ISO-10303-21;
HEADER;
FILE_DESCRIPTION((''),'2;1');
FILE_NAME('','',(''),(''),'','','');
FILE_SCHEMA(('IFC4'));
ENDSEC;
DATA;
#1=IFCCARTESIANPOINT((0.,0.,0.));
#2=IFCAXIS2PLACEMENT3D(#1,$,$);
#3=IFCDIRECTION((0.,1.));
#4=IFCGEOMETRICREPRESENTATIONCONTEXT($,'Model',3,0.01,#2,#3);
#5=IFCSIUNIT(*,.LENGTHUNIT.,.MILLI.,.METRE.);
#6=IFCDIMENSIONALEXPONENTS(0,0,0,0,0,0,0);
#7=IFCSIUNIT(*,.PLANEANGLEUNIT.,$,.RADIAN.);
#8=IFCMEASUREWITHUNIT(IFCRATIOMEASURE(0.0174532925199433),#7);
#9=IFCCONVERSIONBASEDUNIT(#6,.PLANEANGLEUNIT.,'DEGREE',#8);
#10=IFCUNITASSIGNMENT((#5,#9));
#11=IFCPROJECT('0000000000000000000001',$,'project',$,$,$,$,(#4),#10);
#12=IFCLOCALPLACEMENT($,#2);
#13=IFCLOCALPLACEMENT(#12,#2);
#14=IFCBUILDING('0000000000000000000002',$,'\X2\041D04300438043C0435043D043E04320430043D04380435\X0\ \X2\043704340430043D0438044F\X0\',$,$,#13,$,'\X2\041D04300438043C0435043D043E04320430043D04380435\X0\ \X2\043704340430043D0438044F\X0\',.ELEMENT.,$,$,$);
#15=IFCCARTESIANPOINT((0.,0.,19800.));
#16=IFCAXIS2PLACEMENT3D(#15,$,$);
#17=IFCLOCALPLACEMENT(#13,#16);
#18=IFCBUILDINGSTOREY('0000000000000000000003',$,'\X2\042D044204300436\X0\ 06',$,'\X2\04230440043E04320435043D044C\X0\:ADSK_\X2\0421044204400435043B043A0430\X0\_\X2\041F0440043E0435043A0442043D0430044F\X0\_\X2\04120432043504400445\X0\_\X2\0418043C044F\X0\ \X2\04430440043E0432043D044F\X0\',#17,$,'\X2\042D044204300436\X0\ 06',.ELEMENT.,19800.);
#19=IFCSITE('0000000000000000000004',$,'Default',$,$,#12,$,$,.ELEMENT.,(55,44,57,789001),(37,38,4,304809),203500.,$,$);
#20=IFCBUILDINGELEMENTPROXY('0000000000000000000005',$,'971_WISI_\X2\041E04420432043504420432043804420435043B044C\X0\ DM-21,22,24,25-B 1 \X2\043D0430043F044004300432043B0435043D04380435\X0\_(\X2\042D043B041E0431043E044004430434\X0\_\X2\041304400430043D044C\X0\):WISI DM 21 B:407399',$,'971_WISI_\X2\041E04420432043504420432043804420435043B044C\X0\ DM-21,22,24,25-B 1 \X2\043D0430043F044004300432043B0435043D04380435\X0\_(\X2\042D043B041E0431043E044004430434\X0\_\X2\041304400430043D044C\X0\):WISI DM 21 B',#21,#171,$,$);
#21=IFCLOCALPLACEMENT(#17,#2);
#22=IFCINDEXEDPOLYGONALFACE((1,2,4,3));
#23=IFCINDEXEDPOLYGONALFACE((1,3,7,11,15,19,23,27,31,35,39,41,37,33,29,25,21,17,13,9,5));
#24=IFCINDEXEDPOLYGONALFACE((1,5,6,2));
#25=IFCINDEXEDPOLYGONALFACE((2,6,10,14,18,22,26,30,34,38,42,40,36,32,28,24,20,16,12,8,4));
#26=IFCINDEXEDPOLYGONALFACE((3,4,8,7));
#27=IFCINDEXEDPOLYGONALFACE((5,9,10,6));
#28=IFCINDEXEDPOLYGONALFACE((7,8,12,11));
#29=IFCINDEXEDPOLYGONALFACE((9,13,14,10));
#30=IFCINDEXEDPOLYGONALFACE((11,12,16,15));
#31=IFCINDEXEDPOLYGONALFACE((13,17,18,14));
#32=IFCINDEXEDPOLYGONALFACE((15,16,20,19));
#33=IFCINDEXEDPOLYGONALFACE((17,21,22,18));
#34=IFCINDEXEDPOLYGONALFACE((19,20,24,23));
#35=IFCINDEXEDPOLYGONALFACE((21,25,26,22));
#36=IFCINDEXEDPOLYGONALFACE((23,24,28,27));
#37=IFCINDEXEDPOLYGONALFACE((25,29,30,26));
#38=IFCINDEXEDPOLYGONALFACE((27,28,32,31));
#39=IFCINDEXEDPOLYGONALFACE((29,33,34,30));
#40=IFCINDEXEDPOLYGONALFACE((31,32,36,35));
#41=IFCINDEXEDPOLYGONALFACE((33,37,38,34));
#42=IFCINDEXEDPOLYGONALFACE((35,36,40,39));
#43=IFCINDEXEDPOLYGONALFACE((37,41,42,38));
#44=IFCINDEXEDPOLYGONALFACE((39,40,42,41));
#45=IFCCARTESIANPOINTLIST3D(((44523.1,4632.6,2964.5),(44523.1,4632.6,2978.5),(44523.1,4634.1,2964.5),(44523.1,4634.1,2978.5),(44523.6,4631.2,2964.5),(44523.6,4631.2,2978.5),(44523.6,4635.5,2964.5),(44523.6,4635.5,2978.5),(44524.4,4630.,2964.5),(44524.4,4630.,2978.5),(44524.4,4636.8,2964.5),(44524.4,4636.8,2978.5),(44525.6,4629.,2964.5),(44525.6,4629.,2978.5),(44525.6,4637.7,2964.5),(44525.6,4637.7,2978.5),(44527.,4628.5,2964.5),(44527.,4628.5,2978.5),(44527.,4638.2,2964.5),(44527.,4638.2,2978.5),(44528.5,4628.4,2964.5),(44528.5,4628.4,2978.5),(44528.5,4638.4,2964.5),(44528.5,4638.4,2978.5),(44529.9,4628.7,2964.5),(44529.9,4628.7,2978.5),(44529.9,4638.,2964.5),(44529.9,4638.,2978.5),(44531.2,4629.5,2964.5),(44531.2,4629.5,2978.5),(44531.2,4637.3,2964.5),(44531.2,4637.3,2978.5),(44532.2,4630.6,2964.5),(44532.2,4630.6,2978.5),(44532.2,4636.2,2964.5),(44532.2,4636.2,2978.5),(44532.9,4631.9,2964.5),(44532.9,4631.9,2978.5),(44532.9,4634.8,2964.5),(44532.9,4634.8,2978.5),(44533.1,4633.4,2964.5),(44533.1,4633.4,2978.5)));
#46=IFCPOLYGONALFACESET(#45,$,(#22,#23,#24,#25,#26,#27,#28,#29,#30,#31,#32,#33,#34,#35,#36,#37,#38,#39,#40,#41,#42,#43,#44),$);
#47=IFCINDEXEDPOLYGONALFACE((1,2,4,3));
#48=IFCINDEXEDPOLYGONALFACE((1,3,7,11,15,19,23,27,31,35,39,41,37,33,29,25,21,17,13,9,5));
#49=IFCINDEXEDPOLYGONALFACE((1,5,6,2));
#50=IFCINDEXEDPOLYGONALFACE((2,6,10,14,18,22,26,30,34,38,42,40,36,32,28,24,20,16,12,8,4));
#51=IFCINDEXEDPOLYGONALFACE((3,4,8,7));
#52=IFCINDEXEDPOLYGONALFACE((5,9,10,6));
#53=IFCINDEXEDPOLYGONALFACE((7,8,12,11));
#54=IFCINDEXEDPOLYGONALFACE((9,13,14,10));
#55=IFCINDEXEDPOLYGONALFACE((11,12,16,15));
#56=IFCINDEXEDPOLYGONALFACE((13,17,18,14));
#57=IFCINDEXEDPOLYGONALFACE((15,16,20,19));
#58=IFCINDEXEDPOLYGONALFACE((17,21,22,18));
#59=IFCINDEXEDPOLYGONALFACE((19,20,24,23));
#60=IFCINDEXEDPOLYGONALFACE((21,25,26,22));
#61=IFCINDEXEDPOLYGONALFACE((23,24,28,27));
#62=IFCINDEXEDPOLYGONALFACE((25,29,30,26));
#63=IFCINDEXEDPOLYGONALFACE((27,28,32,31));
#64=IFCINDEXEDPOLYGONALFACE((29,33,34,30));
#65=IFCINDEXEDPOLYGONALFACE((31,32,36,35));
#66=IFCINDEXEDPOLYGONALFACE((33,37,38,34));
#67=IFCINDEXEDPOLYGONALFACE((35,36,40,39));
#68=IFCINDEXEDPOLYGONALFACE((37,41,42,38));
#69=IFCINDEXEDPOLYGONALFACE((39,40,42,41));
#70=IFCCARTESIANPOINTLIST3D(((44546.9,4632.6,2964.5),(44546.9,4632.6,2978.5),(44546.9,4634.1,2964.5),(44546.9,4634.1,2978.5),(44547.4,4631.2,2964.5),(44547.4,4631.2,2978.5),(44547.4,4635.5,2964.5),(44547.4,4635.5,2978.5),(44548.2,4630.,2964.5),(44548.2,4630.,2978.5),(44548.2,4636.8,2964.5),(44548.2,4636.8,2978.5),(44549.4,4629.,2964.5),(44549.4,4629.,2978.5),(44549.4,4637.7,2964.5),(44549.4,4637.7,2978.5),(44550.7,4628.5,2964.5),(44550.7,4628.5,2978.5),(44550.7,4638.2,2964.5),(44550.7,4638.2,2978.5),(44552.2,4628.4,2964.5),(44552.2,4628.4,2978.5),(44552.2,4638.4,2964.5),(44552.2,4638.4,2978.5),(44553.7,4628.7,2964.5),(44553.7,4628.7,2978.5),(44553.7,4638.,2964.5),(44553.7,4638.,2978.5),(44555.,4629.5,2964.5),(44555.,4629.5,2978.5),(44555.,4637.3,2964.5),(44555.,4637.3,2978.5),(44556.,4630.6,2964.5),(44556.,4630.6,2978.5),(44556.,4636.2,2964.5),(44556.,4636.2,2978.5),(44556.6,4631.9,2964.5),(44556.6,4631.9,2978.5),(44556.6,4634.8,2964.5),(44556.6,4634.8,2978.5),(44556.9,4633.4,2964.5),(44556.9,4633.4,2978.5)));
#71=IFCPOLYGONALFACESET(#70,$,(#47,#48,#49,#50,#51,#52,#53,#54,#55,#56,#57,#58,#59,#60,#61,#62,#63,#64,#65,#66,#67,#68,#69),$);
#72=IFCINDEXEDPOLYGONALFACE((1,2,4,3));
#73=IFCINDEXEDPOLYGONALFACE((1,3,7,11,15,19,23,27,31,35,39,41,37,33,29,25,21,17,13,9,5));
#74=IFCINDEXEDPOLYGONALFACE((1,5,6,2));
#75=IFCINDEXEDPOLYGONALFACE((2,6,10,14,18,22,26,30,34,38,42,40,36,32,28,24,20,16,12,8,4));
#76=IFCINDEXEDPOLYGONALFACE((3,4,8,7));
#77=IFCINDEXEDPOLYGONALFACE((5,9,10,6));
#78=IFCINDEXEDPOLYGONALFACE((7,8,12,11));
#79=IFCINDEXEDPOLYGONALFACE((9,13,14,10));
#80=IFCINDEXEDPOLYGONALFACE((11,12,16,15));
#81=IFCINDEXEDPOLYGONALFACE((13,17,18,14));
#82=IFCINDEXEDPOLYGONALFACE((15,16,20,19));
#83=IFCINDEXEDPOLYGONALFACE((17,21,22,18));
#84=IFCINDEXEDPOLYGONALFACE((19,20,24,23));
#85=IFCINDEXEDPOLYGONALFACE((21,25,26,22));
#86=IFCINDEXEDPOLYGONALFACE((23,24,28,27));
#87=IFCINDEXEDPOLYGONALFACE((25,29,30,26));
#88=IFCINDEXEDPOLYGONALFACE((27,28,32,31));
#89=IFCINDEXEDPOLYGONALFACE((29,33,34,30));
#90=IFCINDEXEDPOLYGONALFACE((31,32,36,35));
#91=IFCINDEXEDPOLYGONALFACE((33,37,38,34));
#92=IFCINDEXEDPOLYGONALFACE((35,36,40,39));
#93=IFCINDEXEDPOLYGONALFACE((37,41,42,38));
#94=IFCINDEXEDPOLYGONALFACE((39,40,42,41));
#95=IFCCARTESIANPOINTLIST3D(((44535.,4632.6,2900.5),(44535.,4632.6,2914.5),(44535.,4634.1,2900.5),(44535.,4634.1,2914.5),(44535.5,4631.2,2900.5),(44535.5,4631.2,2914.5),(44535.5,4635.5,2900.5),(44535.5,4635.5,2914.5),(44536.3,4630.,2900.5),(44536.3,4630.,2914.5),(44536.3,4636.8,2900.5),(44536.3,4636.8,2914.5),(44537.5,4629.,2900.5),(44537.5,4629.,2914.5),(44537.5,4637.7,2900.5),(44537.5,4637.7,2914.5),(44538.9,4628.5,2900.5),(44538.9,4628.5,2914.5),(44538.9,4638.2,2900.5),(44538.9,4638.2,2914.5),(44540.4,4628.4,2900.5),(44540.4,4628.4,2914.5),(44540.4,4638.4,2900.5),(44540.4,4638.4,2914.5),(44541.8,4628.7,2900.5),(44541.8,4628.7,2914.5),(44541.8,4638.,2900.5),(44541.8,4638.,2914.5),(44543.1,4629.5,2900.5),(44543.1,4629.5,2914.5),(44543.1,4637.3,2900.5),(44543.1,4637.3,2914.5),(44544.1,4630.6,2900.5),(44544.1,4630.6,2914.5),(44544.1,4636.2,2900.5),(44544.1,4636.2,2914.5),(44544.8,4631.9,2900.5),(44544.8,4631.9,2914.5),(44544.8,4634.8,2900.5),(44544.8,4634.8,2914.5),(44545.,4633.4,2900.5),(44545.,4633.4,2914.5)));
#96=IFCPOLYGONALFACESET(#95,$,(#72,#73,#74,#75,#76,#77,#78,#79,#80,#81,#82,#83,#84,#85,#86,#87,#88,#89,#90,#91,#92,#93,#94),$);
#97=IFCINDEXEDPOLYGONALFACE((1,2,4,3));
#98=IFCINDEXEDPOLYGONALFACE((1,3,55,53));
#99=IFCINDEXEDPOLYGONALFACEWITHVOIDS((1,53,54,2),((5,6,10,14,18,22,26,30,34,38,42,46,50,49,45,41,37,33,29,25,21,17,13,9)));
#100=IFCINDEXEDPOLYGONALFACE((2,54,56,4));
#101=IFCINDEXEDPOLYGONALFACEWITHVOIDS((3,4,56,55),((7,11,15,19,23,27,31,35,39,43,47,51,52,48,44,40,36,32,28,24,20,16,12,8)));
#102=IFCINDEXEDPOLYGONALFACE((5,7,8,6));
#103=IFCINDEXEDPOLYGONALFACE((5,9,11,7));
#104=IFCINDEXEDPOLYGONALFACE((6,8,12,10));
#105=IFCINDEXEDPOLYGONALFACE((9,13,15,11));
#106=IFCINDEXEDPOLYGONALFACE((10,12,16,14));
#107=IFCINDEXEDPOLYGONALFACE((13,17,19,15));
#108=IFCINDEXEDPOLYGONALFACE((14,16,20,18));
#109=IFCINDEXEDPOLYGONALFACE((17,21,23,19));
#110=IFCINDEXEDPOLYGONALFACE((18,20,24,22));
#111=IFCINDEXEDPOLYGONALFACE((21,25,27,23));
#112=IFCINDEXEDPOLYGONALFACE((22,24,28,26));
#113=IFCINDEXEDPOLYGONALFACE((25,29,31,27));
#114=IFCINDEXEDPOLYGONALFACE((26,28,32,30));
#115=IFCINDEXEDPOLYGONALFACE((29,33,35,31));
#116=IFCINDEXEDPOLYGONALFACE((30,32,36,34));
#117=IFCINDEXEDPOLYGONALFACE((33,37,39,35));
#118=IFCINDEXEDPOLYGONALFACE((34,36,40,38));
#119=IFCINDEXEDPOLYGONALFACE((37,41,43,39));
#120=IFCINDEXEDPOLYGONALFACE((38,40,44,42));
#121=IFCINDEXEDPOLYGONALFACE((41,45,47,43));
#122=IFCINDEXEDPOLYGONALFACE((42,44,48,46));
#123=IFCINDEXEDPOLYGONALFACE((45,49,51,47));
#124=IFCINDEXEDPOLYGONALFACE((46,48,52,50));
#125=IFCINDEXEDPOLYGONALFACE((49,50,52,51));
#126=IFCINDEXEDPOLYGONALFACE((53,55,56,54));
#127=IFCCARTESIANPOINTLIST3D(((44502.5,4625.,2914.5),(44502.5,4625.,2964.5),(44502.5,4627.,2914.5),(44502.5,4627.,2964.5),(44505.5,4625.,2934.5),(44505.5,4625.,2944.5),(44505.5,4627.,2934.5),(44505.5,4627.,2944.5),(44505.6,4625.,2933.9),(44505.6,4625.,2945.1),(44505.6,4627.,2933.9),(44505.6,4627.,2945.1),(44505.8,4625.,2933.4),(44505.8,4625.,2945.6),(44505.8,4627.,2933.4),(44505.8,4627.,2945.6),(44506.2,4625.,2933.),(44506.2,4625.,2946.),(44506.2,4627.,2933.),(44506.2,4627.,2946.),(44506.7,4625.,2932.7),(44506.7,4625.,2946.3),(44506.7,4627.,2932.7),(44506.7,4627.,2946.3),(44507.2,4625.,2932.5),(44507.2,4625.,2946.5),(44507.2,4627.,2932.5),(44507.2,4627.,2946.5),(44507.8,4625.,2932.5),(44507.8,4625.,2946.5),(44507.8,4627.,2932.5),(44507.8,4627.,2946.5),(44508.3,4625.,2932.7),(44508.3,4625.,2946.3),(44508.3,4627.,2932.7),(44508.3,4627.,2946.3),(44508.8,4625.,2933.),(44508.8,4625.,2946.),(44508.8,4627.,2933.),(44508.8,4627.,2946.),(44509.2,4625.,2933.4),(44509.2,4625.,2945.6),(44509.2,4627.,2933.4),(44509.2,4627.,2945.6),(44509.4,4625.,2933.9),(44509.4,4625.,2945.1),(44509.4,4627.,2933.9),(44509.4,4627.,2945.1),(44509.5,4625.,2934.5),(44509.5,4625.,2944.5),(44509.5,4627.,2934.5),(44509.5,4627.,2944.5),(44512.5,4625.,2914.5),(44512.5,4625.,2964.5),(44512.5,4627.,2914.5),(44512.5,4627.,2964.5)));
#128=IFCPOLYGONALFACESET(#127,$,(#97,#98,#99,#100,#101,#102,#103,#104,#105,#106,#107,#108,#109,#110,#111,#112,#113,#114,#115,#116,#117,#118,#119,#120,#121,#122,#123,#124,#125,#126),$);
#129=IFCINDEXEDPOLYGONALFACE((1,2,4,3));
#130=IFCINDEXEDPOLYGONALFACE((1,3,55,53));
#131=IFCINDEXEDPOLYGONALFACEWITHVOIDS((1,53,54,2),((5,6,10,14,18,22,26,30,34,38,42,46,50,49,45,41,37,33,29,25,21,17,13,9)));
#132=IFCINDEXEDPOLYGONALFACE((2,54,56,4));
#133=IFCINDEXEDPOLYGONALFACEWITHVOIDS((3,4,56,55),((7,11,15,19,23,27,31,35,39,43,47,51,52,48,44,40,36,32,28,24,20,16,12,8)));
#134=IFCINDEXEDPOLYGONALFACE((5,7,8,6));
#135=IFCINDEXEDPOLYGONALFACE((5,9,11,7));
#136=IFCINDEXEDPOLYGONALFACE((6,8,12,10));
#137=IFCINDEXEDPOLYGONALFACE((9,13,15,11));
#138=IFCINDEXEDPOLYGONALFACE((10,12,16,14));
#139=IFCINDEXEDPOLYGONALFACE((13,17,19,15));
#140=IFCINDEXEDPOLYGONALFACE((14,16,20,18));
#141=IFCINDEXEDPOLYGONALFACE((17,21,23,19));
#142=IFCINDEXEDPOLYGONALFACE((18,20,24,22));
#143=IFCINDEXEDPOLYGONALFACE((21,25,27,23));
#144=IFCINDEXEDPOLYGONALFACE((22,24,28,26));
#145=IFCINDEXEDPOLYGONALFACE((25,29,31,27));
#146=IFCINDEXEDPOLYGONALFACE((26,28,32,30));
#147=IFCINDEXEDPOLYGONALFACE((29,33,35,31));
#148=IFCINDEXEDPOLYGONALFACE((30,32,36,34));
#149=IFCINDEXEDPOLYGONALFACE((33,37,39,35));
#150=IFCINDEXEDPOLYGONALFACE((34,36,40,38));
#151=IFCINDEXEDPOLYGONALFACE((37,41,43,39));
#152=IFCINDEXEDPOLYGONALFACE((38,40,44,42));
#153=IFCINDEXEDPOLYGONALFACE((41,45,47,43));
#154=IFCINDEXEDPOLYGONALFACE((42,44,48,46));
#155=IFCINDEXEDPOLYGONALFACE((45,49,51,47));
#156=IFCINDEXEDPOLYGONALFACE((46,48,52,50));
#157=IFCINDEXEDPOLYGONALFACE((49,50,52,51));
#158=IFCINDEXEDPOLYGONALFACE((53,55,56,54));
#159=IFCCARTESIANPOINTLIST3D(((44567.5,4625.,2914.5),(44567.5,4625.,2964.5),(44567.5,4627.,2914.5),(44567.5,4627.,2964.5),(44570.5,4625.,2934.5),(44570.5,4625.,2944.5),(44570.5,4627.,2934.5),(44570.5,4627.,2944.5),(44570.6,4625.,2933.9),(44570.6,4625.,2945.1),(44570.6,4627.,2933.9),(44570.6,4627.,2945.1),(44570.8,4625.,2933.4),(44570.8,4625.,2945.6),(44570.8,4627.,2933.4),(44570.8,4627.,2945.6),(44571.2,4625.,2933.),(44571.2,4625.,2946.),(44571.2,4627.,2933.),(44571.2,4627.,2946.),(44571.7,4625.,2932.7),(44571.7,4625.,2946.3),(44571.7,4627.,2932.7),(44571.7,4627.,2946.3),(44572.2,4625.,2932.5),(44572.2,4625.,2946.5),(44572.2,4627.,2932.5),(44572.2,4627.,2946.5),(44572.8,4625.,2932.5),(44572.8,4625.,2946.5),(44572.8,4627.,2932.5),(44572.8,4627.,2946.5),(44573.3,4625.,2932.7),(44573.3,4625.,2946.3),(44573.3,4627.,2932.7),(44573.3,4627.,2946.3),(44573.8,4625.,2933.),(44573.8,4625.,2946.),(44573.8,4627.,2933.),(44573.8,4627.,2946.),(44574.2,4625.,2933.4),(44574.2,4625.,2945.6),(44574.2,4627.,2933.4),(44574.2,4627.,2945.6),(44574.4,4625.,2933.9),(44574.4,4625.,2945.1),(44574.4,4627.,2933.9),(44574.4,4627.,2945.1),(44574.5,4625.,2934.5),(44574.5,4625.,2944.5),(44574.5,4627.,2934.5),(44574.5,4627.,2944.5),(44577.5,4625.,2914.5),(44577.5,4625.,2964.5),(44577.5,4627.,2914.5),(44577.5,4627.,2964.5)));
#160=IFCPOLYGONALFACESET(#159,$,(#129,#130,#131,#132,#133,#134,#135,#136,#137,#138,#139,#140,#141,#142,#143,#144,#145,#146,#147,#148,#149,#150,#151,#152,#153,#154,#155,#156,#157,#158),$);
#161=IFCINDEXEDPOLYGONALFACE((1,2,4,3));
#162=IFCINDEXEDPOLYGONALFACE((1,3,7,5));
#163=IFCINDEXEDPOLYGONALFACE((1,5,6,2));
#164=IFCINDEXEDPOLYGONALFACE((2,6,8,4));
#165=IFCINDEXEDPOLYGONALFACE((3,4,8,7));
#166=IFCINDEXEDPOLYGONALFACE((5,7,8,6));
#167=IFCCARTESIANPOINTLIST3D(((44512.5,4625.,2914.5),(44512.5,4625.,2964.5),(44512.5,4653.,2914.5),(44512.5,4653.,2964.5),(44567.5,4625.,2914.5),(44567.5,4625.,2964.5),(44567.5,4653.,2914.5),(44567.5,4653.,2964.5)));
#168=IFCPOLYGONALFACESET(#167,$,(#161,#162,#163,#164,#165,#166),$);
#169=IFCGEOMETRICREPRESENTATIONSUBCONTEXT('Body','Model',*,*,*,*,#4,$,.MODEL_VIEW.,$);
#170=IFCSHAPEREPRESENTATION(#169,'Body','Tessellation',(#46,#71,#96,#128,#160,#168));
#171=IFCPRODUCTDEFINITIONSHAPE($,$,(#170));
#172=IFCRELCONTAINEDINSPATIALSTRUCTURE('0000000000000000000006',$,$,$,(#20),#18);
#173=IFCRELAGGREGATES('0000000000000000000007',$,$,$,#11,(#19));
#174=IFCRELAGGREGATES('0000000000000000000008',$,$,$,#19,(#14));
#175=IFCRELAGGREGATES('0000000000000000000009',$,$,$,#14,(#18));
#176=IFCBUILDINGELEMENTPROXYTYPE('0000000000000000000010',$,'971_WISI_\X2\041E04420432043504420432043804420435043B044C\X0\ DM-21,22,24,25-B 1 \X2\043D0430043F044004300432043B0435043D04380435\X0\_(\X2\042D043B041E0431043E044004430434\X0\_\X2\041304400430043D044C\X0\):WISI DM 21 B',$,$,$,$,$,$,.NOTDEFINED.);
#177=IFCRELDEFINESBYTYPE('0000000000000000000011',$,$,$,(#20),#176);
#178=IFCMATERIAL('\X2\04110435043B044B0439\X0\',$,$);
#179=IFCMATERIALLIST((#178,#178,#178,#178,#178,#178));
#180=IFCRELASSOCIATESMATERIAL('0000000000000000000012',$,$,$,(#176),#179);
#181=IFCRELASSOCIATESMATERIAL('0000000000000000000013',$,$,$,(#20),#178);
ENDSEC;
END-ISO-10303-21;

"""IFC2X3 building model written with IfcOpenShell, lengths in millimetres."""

from ifc_helpers import new_model, entity, si_unit, converted_unit, direction, frame, frame_2d, origin, place, context, subcontext, project, spatial, polyline, circle_curve, parameter, trimmed, segment, composite_curve, rectangle, circle, outline, extrude, source, transform, mapped, material, material_list, type_object, type_shapes, element, save


model = new_model("IFC2X3")

# Units and contexts
model_context = context("Model", 3, precision=0.01, world=origin(), true_north=direction((0.0, 1.0)))
body_context = subcontext(model_context, "Body", "Model", "MODEL_VIEW")
ifc_project = project(units=[si_unit("LENGTHUNIT", "METRE", prefix="MILLI"), converted_unit("PLANEANGLEUNIT", "DEGREE", entity("IfcRatioMeasure", 0.0174532925199433), si_unit("PLANEANGLEUNIT", "RADIAN"), dimensions=[0, 0, 0, 0, 0, 0, 0])], contexts=[model_context])

# Site, building, storey
site_placement = place(None, frame((0.0, 0.0, 0.0)))
site = spatial("IfcSite", under=ifc_project, at=site_placement, Name="Default", CompositionType="ELEMENT", RefLatitude=(55, 44, 57, 789001), RefLongitude=(37, 38, 4, 304809), RefElevation=203500.0)
building_placement = place(site_placement, origin())
building = spatial("IfcBuilding", under=site, at=building_placement, Name="Наименование здания", LongName="Наименование здания", CompositionType="ELEMENT")
storey_placement = place(building_placement, frame((0.0, 0.0, 19800.0)))
storey = spatial("IfcBuildingStorey", under=building, at=storey_placement, Name="Этаж 06", ObjectType="Уровень:ADSK_Стрелка_Проектная_Вверх_Имя уровня", LongName="Этаж 06", CompositionType="ELEMENT", Elevation=19800.0)

# Building element proxy
ifc_material_1 = material(Name="Белый")
ifc_material_list_1 = material_list([ifc_material_1, ifc_material_1, ifc_material_1, ifc_material_1, ifc_material_1, ifc_material_1])
building_element_proxy_type_1 = type_object("IfcBuildingElementProxyType", Name="971_WISI_Ответвитель DM-21,22,24,25-B 1 направление_(ЭлОборуд_Грань):WISI DM 21 B", PredefinedType="NOTDEFINED", material=ifc_material_list_1)
shared_shape_1 = source(origin(), body_context, "Body", "SweptSolid", [
    extrude(circle(Radius=5.0, at=frame_2d((0.0, 0.0), x_axis=(1.0, 0.0))), frame((11.9, 25.0, 8.4), z_axis=(0.0, 1.0, 0.0), x_axis=(-1.0, 0.0, 0.0)), (0.0, 0.0, 1.0), 14.0),
    extrude(circle(Radius=5.0, at=frame_2d((0.0, 0.0), x_axis=(1.0, 0.0))), frame((-11.8, 25.0, 8.4), z_axis=(0.0, 1.0, 0.0), x_axis=(-1.0, 0.0, 0.0)), (0.0, 0.0, 1.0), 14.0),
    extrude(circle(Radius=5.0, at=frame_2d((0.0, 0.0), x_axis=(1.0, 0.0))), frame((0.0, -39.0, 8.4), z_axis=(0.0, 1.0, 0.0), x_axis=(-1.0, 0.0, 0.0)), (0.0, 0.0, 1.0), 14.0),
    extrude(outline(polyline([(-5.0, -25.0), (5.0, -25.0), (5.0, 25.0), (-5.0, 25.0), (-5.0, -25.0)]), holes=[composite_curve([segment(polyline([(2.0, 5.0), (2.0, -5.0)]), True, "CONTINUOUS"), segment(trimmed(circle_curve(frame_2d((0.0, -5.0), x_axis=(-1.0, 0.0)), 2.0), [parameter(0.0)], [parameter(180.0)], True, "PARAMETER"), False, "CONTINUOUS"), segment(polyline([(-2.0, -5.0), (-2.0, 5.0)]), True, "CONTINUOUS"), segment(trimmed(circle_curve(frame_2d((0.0, 5.0), x_axis=(-1.0, 0.0)), 2.0), [parameter(180.0)], [parameter(0.0)], True, "PARAMETER"), False, "CONTINUOUS")], self_intersect=False)]), frame((32.5, 0.0, 0.0), z_axis=(0.0, 0.0, 1.0), x_axis=(-1.0, 0.0, 0.0)), (0.0, 0.0, 1.0), 2.0),
    extrude(outline(polyline([(-5.0, -25.0), (5.0, -25.0), (5.0, 25.0), (-5.0, 25.0), (-5.0, -25.0)]), holes=[composite_curve([segment(polyline([(-2.0, -5.0), (-2.0, 5.0)]), True, "CONTINUOUS"), segment(trimmed(circle_curve(frame_2d((0.0, 5.0), x_axis=(-1.0, 0.0)), 2.0), [parameter(180.0)], [parameter(0.0)], True, "PARAMETER"), False, "CONTINUOUS"), segment(polyline([(2.0, 5.0), (2.0, -5.0)]), True, "CONTINUOUS"), segment(trimmed(circle_curve(frame_2d((0.0, -5.0), x_axis=(-1.0, 0.0)), 2.0), [parameter(0.0)], [parameter(180.0)], True, "PARAMETER"), False, "CONTINUOUS")], self_intersect=False)]), frame((-32.5, 0.0, 0.0), z_axis=(0.0, 0.0, 1.0), x_axis=(-1.0, 0.0, 0.0)), (0.0, 0.0, 1.0), 2.0),
    extrude(rectangle(XDim=55.0, YDim=50.0, at=frame_2d((0.0, 0.0), x_axis=(1.0, 0.0))), frame((0.0, 0.0, 0.0), z_axis=(0.0, 0.0, 1.0), x_axis=(-1.0, 0.0, 0.0)), (0.0, 0.0, 1.0), 28.0),
])
type_shapes(building_element_proxy_type_1, [shared_shape_1])
for number, where, z_axis, x_axis, name in (
    (1, (44540.0, 4625.0, 2939.5), (0.0, 1.0, 0.0), (-1.0, 0.0, 0.0), "971_WISI_Ответвитель DM-21,22,24,25-B 1 направление_(ЭлОборуд_Грань):WISI DM 21 B:407399"),
):
    element("IfcBuildingElementProxy", number, at=place(storey_placement, frame(where, z_axis=z_axis, x_axis=x_axis)), inside=storey, type_object=building_element_proxy_type_1, material=ifc_material_1, Name=name, ObjectType="971_WISI_Ответвитель DM-21,22,24,25-B 1 направление_(ЭлОборуд_Грань):WISI DM 21 B", context=body_context, shape_type="MappedRepresentation", body=[
        mapped(shared_shape_1, transform((0.0, 0.0, 0.0), scale=1.0)),
    ])

save(model, "model.ifc")
